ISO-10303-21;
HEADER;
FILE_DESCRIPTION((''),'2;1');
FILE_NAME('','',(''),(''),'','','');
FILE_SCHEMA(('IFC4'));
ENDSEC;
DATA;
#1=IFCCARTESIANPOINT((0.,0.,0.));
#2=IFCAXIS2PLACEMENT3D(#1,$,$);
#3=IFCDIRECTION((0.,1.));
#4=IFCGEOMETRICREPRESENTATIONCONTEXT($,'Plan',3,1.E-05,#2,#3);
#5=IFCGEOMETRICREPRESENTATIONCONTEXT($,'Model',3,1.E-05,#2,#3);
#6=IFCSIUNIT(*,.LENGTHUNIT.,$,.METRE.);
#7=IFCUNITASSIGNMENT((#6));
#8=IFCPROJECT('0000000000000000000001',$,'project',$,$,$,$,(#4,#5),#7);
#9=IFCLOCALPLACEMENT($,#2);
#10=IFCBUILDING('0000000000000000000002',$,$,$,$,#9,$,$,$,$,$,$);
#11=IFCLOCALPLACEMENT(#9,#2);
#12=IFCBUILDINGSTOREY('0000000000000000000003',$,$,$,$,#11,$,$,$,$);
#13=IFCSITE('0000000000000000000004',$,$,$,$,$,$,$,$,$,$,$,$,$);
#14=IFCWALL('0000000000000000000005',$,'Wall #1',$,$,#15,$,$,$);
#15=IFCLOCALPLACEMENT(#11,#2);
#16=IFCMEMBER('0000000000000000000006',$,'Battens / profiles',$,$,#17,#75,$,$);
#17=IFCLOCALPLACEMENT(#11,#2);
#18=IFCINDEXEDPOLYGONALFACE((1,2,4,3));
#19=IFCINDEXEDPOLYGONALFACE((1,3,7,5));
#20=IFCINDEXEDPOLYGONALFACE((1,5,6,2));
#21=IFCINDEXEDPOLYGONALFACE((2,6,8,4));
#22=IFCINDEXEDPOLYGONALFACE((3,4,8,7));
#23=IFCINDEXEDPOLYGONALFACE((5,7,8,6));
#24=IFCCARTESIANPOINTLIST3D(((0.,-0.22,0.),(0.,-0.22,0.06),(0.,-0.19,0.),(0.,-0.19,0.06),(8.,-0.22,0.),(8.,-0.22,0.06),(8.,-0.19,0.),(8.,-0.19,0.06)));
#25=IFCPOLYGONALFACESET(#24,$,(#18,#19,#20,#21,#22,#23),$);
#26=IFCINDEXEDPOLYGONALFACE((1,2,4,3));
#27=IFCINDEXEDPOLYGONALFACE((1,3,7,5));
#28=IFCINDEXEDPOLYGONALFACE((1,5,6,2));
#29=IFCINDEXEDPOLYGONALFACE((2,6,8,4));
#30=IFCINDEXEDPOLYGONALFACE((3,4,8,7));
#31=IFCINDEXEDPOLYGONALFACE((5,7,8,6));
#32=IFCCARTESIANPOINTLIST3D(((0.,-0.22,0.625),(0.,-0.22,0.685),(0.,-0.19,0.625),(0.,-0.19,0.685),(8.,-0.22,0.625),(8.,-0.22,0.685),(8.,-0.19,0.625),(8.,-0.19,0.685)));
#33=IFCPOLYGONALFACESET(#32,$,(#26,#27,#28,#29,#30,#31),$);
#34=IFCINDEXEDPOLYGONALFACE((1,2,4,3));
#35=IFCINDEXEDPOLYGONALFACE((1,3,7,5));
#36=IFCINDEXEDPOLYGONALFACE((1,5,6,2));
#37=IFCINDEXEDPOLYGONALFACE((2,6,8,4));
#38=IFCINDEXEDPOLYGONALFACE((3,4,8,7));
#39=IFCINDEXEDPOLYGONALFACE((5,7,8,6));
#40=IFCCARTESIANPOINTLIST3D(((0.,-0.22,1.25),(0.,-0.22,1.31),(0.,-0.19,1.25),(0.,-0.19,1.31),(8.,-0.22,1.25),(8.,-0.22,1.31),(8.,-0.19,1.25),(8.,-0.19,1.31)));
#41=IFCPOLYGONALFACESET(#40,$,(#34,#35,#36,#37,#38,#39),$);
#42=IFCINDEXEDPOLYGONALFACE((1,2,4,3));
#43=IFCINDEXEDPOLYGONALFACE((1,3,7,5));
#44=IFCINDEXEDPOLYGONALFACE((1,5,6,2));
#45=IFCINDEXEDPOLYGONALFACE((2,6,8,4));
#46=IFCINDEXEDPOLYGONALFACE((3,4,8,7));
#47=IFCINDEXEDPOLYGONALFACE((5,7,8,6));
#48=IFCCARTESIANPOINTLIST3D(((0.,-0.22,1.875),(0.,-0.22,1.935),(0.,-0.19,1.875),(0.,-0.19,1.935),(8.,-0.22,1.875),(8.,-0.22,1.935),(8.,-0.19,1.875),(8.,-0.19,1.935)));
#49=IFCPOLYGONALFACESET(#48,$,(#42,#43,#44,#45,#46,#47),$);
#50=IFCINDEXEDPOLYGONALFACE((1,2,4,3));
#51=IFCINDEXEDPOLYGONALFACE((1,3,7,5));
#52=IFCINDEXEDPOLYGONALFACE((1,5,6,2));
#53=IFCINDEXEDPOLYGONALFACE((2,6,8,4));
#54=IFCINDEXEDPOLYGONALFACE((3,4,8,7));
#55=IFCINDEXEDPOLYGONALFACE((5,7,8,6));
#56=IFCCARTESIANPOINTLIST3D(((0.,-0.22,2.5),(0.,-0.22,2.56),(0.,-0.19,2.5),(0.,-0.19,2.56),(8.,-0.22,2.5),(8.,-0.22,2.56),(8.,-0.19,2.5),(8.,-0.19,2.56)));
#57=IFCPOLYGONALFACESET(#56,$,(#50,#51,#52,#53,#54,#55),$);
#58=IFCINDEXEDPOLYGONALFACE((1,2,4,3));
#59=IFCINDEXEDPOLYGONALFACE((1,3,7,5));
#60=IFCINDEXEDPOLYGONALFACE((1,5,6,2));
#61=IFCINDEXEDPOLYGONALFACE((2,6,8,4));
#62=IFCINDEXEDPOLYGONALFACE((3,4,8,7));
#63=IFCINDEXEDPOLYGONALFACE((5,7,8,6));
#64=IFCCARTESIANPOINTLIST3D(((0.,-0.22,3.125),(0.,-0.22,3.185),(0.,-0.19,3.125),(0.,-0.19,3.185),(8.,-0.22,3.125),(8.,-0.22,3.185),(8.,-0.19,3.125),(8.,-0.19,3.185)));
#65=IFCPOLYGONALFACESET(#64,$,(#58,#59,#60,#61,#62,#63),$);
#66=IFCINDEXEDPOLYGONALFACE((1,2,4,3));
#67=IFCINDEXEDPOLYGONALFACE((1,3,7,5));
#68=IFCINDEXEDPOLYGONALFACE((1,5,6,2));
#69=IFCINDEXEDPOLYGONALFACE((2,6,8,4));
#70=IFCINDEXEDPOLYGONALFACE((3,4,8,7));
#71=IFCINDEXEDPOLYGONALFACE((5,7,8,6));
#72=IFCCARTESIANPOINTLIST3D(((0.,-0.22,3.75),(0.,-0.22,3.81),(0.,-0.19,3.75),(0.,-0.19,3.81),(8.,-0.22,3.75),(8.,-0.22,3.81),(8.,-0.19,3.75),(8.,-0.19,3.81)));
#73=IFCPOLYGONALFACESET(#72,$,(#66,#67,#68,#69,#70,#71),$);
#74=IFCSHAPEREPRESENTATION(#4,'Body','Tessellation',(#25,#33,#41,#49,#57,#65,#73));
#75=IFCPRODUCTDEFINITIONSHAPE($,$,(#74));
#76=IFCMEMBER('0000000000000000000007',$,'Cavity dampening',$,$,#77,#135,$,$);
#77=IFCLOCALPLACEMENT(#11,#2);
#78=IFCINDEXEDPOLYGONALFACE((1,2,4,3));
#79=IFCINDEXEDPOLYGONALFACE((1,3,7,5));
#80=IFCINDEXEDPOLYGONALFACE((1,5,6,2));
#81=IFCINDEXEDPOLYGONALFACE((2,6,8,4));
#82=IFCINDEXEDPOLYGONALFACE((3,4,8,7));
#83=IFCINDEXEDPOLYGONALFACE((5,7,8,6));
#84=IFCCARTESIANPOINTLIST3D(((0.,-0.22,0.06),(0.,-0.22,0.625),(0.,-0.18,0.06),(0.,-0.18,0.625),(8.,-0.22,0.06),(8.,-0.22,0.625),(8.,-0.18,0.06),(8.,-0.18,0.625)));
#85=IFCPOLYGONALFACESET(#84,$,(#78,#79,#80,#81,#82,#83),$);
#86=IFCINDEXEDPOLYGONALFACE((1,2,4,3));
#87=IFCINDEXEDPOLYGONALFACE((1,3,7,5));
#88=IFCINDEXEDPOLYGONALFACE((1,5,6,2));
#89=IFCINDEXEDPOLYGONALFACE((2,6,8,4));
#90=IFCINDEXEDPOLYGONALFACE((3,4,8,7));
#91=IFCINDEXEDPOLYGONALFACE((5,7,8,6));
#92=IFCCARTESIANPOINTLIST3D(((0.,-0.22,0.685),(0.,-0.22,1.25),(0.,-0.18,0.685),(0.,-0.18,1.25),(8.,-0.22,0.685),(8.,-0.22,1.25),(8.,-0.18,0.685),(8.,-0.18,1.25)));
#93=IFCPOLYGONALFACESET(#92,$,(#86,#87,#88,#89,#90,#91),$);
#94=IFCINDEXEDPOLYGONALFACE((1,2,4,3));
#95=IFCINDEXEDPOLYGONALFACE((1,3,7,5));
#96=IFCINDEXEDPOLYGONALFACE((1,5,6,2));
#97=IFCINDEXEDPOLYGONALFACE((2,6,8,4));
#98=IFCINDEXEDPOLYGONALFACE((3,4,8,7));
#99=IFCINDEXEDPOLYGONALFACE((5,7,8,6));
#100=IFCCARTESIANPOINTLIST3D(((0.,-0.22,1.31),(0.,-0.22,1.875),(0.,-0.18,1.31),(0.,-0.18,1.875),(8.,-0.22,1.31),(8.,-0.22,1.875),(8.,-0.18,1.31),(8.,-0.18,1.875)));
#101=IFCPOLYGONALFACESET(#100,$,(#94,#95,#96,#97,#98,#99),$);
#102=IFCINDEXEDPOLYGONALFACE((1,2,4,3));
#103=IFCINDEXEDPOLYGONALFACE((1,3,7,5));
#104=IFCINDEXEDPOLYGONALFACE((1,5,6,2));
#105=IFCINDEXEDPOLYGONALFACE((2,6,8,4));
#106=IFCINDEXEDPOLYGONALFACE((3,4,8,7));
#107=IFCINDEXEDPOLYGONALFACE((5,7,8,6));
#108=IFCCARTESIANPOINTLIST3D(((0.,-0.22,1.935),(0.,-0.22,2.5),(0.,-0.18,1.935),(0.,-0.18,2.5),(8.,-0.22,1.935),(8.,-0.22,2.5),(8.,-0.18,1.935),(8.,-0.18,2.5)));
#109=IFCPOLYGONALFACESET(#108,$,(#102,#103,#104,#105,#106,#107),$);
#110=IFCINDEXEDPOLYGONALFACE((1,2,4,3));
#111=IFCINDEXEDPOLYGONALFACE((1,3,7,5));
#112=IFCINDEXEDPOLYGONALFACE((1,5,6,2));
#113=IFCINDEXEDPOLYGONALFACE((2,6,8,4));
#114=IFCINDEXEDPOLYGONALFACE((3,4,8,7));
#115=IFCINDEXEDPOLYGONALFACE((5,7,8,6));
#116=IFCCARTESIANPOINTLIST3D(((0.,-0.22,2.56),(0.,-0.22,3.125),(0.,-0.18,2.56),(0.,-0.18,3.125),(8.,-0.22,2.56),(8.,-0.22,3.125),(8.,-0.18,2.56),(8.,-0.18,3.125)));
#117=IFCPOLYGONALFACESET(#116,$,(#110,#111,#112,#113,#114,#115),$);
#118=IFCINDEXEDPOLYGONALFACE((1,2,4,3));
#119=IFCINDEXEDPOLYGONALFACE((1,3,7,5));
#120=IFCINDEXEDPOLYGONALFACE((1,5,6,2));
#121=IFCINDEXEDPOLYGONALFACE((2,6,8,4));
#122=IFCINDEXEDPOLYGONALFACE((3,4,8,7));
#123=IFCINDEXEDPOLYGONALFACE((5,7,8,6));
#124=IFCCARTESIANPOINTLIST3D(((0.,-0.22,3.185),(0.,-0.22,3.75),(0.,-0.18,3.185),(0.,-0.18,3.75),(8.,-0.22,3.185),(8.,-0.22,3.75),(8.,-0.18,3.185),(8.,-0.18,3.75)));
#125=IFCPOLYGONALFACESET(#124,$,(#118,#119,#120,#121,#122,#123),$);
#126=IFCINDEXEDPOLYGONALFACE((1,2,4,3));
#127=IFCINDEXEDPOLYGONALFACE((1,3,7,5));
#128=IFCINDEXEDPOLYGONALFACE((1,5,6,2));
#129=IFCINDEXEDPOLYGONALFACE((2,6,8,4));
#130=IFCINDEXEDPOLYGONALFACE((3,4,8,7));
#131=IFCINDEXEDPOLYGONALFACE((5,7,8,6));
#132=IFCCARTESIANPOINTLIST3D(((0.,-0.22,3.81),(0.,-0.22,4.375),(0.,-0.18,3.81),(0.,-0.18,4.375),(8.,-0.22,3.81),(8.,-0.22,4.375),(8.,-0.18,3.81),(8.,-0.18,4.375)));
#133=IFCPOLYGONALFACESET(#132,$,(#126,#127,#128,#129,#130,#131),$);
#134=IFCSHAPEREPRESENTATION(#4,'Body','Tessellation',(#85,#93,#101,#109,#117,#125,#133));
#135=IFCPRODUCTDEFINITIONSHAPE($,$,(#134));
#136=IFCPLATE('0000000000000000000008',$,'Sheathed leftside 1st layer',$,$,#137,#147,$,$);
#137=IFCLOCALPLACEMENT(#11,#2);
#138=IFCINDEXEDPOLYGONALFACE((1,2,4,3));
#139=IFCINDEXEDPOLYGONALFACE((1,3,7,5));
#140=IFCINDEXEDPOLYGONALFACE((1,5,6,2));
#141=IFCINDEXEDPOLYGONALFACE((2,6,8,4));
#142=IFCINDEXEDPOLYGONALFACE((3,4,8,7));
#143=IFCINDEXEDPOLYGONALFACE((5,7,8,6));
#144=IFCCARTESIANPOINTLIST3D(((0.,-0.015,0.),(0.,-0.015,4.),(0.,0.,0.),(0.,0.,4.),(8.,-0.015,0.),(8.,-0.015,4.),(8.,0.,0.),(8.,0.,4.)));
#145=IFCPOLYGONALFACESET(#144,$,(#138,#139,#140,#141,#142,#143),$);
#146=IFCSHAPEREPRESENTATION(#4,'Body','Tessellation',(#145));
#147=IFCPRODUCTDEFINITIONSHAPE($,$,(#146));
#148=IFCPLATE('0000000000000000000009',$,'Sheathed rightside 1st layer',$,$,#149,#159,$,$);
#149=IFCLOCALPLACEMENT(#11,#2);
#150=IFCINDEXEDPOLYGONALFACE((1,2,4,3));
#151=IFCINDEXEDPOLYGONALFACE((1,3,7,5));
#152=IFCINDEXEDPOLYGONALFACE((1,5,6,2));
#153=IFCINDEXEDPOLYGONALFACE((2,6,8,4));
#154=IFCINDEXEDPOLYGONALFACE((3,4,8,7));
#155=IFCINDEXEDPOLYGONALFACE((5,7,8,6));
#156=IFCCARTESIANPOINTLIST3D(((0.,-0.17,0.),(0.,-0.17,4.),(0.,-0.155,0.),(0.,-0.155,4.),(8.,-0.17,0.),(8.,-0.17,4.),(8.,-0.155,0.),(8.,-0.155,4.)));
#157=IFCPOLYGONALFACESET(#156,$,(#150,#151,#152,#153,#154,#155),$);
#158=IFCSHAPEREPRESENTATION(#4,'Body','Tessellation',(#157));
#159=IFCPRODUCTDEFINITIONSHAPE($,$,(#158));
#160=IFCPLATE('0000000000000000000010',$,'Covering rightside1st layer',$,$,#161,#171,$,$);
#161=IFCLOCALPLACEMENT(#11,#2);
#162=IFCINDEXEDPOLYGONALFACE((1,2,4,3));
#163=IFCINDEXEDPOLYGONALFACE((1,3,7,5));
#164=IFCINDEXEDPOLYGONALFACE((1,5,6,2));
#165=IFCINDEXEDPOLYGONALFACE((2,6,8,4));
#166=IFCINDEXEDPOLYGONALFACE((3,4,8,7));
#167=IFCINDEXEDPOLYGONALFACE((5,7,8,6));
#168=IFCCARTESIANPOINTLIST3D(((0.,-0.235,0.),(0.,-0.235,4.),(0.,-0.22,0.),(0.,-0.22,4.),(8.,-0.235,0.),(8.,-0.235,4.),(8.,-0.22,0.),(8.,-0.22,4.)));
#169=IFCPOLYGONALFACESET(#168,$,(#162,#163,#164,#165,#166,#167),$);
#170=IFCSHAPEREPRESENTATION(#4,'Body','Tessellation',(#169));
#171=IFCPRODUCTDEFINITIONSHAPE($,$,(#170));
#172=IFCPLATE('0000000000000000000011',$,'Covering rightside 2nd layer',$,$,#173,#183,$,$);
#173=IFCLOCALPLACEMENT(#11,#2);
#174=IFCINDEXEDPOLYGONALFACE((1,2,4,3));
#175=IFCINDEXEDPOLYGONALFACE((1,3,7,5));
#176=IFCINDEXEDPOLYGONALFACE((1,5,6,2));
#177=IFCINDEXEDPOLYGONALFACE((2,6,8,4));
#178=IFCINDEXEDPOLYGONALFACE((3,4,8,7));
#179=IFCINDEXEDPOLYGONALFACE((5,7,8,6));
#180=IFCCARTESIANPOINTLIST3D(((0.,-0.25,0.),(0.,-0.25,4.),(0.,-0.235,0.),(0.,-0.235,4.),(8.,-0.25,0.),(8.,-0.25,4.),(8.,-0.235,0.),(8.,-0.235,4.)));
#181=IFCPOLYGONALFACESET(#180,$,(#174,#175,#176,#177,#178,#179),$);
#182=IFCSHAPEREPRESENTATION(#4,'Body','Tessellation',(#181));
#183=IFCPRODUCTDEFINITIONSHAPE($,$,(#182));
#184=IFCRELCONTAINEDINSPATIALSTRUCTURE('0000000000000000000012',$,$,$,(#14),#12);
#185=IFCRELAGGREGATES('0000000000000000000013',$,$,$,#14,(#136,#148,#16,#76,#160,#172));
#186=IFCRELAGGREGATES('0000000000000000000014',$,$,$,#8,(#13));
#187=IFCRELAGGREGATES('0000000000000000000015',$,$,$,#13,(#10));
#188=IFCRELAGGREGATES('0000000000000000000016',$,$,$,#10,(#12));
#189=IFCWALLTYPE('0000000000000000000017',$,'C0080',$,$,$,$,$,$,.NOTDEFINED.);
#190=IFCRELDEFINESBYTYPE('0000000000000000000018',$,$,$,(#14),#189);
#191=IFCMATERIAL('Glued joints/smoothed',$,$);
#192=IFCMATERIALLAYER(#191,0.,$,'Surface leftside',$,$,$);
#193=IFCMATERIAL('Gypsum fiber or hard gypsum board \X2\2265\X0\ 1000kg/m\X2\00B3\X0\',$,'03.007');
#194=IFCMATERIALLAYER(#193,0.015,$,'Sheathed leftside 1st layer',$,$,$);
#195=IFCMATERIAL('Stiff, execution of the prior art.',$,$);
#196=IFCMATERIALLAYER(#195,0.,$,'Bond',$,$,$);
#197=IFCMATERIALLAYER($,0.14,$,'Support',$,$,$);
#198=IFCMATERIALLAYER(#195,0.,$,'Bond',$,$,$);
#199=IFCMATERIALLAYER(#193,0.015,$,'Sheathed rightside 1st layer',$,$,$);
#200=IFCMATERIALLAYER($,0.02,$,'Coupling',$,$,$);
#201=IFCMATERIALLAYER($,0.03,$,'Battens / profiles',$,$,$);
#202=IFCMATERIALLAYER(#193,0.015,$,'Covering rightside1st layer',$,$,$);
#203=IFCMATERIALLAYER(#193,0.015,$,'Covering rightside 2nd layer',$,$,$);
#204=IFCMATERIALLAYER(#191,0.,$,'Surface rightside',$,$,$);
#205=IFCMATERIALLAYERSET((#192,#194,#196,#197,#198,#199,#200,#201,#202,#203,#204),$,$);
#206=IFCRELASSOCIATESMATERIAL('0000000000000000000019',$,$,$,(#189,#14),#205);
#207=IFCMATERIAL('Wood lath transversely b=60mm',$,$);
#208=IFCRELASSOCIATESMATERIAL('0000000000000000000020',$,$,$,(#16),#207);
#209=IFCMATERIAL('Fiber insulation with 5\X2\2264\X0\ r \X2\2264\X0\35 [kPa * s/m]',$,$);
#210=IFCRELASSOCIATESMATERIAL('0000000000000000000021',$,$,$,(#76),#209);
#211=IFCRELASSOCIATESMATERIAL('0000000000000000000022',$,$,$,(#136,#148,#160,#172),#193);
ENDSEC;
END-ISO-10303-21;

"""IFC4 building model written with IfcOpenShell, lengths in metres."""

from ifc_helpers import new_model, si_unit, direction, frame, frame_2d, origin, origin_with_axes, place, context, project, spatial, rectangle, extrude, material, layer, layer_set, type_object, element, aggregate, save


model = new_model("IFC4")

# Units and contexts
plan_context = context("Plan", 3, precision=1e-05, world=origin(), true_north=direction((0.0, 1.0)))
model_context = context("Model", 3, precision=1e-05, world=origin(), true_north=direction((0.0, 1.0)))
ifc_project = project(units=[si_unit("LENGTHUNIT", "METRE")], contexts=[plan_context, model_context])

# Site, building, storey
site = spatial("IfcSite", under=ifc_project)
building_placement = place(None, origin())
building = spatial("IfcBuilding", under=site, at=building_placement)
storey_placement = place(building_placement, origin())
storey = spatial("IfcBuildingStorey", under=building, at=storey_placement)

# Wall, members, plates
ifc_material_1 = material(Name="Glued joints/smoothed")
ifc_layer_1 = layer(ifc_material_1, 0.0, Name="Surface leftside")
ifc_material_2 = material(Name="Gypsum fiber or hard gypsum board ≥ 1000kg/m³", Category="03.007")
ifc_layer_2 = layer(ifc_material_2, 0.015, Name="Sheathed leftside 1st layer")
ifc_material_3 = material(Name="Stiff, execution of the prior art.")
ifc_layer_3 = layer(ifc_material_3, 0.0, Name="Bond")
ifc_layer_4 = layer(None, 0.14, Name="Support")
ifc_layer_5 = layer(ifc_material_3, 0.0, Name="Bond")
ifc_layer_6 = layer(ifc_material_2, 0.015, Name="Sheathed rightside 1st layer")
ifc_layer_7 = layer(None, 0.02, Name="Coupling")
ifc_layer_8 = layer(None, 0.03, Name="Battens / profiles")
ifc_layer_9 = layer(ifc_material_2, 0.015, Name="Covering rightside1st layer")
ifc_layer_10 = layer(ifc_material_2, 0.015, Name="Covering rightside 2nd layer")
ifc_layer_11 = layer(ifc_material_1, 0.0, Name="Surface rightside")
ifc_layer_set = layer_set([ifc_layer_1, ifc_layer_2, ifc_layer_3, ifc_layer_4, ifc_layer_5, ifc_layer_6, ifc_layer_7, ifc_layer_8, ifc_layer_9, ifc_layer_10, ifc_layer_11])
wall_type = type_object("IfcWallType", Name="C0080", PredefinedType="NOTDEFINED", material=ifc_layer_set)
wall_placement = place(None, frame((0.0, 0.0, 0.0), z_axis=(0.0, -1.0, 0.0), x_axis=(1.0, 0.0, 0.0)))
wall = element("IfcWall", 1, at=wall_placement, inside=storey, type_object=wall_type, material=ifc_layer_set, Name="Wall #1")
ifc_material_4 = material(Name="Fiber insulation with 5≤ r ≤35 [kPa * s/m]")
ifc_material_5 = material(Name="Wood lath transversely b=60mm")
member_1_placement = place(wall_placement, origin())
member_1 = element("IfcMember", 2, at=member_1_placement, material=ifc_material_5, Name="Battens / profiles", context=plan_context, shape_type="SweptSolid", body=[
    extrude(rectangle(XDim=0.06, YDim=0.03, at=frame_2d((0.03, 0.015), x_axis=(1.0, 0.0))), frame((0.0, 0.0, 0.19), z_axis=(1.0, 0.0, 0.0), x_axis=(0.0, 1.0, 0.0)), (0.0, 0.0, 1.0), 8.0),
    extrude(rectangle(XDim=0.06, YDim=0.03, at=frame_2d((0.03, 0.015), x_axis=(1.0, 0.0))), frame((0.0, 0.625, 0.19), z_axis=(1.0, 0.0, 0.0), x_axis=(0.0, 1.0, 0.0)), (0.0, 0.0, 1.0), 8.0),
    extrude(rectangle(XDim=0.06, YDim=0.03, at=frame_2d((0.03, 0.015), x_axis=(1.0, 0.0))), frame((0.0, 1.25, 0.19), z_axis=(1.0, 0.0, 0.0), x_axis=(0.0, 1.0, 0.0)), (0.0, 0.0, 1.0), 8.0),
    extrude(rectangle(XDim=0.06, YDim=0.03, at=frame_2d((0.03, 0.015), x_axis=(1.0, 0.0))), frame((0.0, 1.875, 0.19), z_axis=(1.0, 0.0, 0.0), x_axis=(0.0, 1.0, 0.0)), (0.0, 0.0, 1.0), 8.0),
    extrude(rectangle(XDim=0.06, YDim=0.03, at=frame_2d((0.03, 0.015), x_axis=(1.0, 0.0))), frame((0.0, 2.5, 0.19), z_axis=(1.0, 0.0, 0.0), x_axis=(0.0, 1.0, 0.0)), (0.0, 0.0, 1.0), 8.0),
    extrude(rectangle(XDim=0.06, YDim=0.03, at=frame_2d((0.03, 0.015), x_axis=(1.0, 0.0))), frame((0.0, 3.125, 0.19), z_axis=(1.0, 0.0, 0.0), x_axis=(0.0, 1.0, 0.0)), (0.0, 0.0, 1.0), 8.0),
    extrude(rectangle(XDim=0.06, YDim=0.03, at=frame_2d((0.03, 0.015), x_axis=(1.0, 0.0))), frame((0.0, 3.75, 0.19), z_axis=(1.0, 0.0, 0.0), x_axis=(0.0, 1.0, 0.0)), (0.0, 0.0, 1.0), 8.0),
])
member_2_placement = place(wall_placement, origin())
member_2 = element("IfcMember", 3, at=member_2_placement, material=ifc_material_4, Name="Cavity dampening", context=plan_context, shape_type="SweptSolid", body=[
    extrude(rectangle(XDim=0.565, YDim=0.04, at=frame_2d((0.2825, 0.02), x_axis=(1.0, 0.0))), frame((0.0, 0.06, 0.18), z_axis=(1.0, 0.0, 0.0), x_axis=(0.0, 1.0, 0.0)), (0.0, 0.0, 1.0), 8.0),
    extrude(rectangle(XDim=0.565, YDim=0.04, at=frame_2d((0.2825, 0.02), x_axis=(1.0, 0.0))), frame((0.0, 0.685, 0.18), z_axis=(1.0, 0.0, 0.0), x_axis=(0.0, 1.0, 0.0)), (0.0, 0.0, 1.0), 8.0),
    extrude(rectangle(XDim=0.565, YDim=0.04, at=frame_2d((0.2825, 0.02), x_axis=(1.0, 0.0))), frame((0.0, 1.31, 0.18), z_axis=(1.0, 0.0, 0.0), x_axis=(0.0, 1.0, 0.0)), (0.0, 0.0, 1.0), 8.0),
    extrude(rectangle(XDim=0.565, YDim=0.04, at=frame_2d((0.2825, 0.02), x_axis=(1.0, 0.0))), frame((0.0, 1.935, 0.18), z_axis=(1.0, 0.0, 0.0), x_axis=(0.0, 1.0, 0.0)), (0.0, 0.0, 1.0), 8.0),
    extrude(rectangle(XDim=0.565, YDim=0.04, at=frame_2d((0.2825, 0.02), x_axis=(1.0, 0.0))), frame((0.0, 2.56, 0.18), z_axis=(1.0, 0.0, 0.0), x_axis=(0.0, 1.0, 0.0)), (0.0, 0.0, 1.0), 8.0),
    extrude(rectangle(XDim=0.565, YDim=0.04, at=frame_2d((0.2825, 0.02), x_axis=(1.0, 0.0))), frame((0.0, 3.185, 0.18), z_axis=(1.0, 0.0, 0.0), x_axis=(0.0, 1.0, 0.0)), (0.0, 0.0, 1.0), 8.0),
    extrude(rectangle(XDim=0.565, YDim=0.04, at=frame_2d((0.2825, 0.02), x_axis=(1.0, 0.0))), frame((0.0, 3.81, 0.18), z_axis=(1.0, 0.0, 0.0), x_axis=(0.0, 1.0, 0.0)), (0.0, 0.0, 1.0), 8.0),
])
plate_1_placement = place(wall_placement, origin())
plate_1 = element("IfcPlate", 4, at=plate_1_placement, material=ifc_material_2, Name="Sheathed leftside 1st layer", context=plan_context, shape_type="SweptSolid", body=[
    extrude(rectangle(XDim=8.0, YDim=4.0, at=frame_2d((4.0, 2.0), x_axis=(1.0, 0.0))), origin_with_axes(), (0.0, 0.0, 1.0), 0.015),
])
plate_2_placement = place(wall_placement, origin())
plate_2 = element("IfcPlate", 5, at=plate_2_placement, material=ifc_material_2, Name="Sheathed rightside 1st layer", context=plan_context, shape_type="SweptSolid", body=[
    extrude(rectangle(XDim=8.0, YDim=4.0, at=frame_2d((4.0, 2.0), x_axis=(1.0, 0.0))), frame((0.0, 0.0, 0.155), z_axis=(0.0, 0.0, 1.0), x_axis=(1.0, 0.0, 0.0)), (0.0, 0.0, 1.0), 0.015),
])
plate_3_placement = place(wall_placement, origin())
plate_3 = element("IfcPlate", 6, at=plate_3_placement, material=ifc_material_2, Name="Covering rightside1st layer", context=plan_context, shape_type="SweptSolid", body=[
    extrude(rectangle(XDim=8.0, YDim=4.0, at=frame_2d((4.0, 2.0), x_axis=(1.0, 0.0))), frame((0.0, 0.0, 0.22), z_axis=(0.0, 0.0, 1.0), x_axis=(1.0, 0.0, 0.0)), (0.0, 0.0, 1.0), 0.015),
])
plate_4_placement = place(wall_placement, origin())
plate_4 = element("IfcPlate", 7, at=plate_4_placement, material=ifc_material_2, Name="Covering rightside 2nd layer", context=plan_context, shape_type="SweptSolid", body=[
    extrude(rectangle(XDim=8.0, YDim=4.0, at=frame_2d((4.0, 2.0), x_axis=(1.0, 0.0))), frame((0.0, 0.0, 0.235), z_axis=(0.0, 0.0, 1.0), x_axis=(1.0, 0.0, 0.0)), (0.0, 0.0, 1.0), 0.015),
])
aggregate(wall, [plate_1, plate_2, member_1, member_2, plate_3, plate_4])

save(model, "model.ifc")
